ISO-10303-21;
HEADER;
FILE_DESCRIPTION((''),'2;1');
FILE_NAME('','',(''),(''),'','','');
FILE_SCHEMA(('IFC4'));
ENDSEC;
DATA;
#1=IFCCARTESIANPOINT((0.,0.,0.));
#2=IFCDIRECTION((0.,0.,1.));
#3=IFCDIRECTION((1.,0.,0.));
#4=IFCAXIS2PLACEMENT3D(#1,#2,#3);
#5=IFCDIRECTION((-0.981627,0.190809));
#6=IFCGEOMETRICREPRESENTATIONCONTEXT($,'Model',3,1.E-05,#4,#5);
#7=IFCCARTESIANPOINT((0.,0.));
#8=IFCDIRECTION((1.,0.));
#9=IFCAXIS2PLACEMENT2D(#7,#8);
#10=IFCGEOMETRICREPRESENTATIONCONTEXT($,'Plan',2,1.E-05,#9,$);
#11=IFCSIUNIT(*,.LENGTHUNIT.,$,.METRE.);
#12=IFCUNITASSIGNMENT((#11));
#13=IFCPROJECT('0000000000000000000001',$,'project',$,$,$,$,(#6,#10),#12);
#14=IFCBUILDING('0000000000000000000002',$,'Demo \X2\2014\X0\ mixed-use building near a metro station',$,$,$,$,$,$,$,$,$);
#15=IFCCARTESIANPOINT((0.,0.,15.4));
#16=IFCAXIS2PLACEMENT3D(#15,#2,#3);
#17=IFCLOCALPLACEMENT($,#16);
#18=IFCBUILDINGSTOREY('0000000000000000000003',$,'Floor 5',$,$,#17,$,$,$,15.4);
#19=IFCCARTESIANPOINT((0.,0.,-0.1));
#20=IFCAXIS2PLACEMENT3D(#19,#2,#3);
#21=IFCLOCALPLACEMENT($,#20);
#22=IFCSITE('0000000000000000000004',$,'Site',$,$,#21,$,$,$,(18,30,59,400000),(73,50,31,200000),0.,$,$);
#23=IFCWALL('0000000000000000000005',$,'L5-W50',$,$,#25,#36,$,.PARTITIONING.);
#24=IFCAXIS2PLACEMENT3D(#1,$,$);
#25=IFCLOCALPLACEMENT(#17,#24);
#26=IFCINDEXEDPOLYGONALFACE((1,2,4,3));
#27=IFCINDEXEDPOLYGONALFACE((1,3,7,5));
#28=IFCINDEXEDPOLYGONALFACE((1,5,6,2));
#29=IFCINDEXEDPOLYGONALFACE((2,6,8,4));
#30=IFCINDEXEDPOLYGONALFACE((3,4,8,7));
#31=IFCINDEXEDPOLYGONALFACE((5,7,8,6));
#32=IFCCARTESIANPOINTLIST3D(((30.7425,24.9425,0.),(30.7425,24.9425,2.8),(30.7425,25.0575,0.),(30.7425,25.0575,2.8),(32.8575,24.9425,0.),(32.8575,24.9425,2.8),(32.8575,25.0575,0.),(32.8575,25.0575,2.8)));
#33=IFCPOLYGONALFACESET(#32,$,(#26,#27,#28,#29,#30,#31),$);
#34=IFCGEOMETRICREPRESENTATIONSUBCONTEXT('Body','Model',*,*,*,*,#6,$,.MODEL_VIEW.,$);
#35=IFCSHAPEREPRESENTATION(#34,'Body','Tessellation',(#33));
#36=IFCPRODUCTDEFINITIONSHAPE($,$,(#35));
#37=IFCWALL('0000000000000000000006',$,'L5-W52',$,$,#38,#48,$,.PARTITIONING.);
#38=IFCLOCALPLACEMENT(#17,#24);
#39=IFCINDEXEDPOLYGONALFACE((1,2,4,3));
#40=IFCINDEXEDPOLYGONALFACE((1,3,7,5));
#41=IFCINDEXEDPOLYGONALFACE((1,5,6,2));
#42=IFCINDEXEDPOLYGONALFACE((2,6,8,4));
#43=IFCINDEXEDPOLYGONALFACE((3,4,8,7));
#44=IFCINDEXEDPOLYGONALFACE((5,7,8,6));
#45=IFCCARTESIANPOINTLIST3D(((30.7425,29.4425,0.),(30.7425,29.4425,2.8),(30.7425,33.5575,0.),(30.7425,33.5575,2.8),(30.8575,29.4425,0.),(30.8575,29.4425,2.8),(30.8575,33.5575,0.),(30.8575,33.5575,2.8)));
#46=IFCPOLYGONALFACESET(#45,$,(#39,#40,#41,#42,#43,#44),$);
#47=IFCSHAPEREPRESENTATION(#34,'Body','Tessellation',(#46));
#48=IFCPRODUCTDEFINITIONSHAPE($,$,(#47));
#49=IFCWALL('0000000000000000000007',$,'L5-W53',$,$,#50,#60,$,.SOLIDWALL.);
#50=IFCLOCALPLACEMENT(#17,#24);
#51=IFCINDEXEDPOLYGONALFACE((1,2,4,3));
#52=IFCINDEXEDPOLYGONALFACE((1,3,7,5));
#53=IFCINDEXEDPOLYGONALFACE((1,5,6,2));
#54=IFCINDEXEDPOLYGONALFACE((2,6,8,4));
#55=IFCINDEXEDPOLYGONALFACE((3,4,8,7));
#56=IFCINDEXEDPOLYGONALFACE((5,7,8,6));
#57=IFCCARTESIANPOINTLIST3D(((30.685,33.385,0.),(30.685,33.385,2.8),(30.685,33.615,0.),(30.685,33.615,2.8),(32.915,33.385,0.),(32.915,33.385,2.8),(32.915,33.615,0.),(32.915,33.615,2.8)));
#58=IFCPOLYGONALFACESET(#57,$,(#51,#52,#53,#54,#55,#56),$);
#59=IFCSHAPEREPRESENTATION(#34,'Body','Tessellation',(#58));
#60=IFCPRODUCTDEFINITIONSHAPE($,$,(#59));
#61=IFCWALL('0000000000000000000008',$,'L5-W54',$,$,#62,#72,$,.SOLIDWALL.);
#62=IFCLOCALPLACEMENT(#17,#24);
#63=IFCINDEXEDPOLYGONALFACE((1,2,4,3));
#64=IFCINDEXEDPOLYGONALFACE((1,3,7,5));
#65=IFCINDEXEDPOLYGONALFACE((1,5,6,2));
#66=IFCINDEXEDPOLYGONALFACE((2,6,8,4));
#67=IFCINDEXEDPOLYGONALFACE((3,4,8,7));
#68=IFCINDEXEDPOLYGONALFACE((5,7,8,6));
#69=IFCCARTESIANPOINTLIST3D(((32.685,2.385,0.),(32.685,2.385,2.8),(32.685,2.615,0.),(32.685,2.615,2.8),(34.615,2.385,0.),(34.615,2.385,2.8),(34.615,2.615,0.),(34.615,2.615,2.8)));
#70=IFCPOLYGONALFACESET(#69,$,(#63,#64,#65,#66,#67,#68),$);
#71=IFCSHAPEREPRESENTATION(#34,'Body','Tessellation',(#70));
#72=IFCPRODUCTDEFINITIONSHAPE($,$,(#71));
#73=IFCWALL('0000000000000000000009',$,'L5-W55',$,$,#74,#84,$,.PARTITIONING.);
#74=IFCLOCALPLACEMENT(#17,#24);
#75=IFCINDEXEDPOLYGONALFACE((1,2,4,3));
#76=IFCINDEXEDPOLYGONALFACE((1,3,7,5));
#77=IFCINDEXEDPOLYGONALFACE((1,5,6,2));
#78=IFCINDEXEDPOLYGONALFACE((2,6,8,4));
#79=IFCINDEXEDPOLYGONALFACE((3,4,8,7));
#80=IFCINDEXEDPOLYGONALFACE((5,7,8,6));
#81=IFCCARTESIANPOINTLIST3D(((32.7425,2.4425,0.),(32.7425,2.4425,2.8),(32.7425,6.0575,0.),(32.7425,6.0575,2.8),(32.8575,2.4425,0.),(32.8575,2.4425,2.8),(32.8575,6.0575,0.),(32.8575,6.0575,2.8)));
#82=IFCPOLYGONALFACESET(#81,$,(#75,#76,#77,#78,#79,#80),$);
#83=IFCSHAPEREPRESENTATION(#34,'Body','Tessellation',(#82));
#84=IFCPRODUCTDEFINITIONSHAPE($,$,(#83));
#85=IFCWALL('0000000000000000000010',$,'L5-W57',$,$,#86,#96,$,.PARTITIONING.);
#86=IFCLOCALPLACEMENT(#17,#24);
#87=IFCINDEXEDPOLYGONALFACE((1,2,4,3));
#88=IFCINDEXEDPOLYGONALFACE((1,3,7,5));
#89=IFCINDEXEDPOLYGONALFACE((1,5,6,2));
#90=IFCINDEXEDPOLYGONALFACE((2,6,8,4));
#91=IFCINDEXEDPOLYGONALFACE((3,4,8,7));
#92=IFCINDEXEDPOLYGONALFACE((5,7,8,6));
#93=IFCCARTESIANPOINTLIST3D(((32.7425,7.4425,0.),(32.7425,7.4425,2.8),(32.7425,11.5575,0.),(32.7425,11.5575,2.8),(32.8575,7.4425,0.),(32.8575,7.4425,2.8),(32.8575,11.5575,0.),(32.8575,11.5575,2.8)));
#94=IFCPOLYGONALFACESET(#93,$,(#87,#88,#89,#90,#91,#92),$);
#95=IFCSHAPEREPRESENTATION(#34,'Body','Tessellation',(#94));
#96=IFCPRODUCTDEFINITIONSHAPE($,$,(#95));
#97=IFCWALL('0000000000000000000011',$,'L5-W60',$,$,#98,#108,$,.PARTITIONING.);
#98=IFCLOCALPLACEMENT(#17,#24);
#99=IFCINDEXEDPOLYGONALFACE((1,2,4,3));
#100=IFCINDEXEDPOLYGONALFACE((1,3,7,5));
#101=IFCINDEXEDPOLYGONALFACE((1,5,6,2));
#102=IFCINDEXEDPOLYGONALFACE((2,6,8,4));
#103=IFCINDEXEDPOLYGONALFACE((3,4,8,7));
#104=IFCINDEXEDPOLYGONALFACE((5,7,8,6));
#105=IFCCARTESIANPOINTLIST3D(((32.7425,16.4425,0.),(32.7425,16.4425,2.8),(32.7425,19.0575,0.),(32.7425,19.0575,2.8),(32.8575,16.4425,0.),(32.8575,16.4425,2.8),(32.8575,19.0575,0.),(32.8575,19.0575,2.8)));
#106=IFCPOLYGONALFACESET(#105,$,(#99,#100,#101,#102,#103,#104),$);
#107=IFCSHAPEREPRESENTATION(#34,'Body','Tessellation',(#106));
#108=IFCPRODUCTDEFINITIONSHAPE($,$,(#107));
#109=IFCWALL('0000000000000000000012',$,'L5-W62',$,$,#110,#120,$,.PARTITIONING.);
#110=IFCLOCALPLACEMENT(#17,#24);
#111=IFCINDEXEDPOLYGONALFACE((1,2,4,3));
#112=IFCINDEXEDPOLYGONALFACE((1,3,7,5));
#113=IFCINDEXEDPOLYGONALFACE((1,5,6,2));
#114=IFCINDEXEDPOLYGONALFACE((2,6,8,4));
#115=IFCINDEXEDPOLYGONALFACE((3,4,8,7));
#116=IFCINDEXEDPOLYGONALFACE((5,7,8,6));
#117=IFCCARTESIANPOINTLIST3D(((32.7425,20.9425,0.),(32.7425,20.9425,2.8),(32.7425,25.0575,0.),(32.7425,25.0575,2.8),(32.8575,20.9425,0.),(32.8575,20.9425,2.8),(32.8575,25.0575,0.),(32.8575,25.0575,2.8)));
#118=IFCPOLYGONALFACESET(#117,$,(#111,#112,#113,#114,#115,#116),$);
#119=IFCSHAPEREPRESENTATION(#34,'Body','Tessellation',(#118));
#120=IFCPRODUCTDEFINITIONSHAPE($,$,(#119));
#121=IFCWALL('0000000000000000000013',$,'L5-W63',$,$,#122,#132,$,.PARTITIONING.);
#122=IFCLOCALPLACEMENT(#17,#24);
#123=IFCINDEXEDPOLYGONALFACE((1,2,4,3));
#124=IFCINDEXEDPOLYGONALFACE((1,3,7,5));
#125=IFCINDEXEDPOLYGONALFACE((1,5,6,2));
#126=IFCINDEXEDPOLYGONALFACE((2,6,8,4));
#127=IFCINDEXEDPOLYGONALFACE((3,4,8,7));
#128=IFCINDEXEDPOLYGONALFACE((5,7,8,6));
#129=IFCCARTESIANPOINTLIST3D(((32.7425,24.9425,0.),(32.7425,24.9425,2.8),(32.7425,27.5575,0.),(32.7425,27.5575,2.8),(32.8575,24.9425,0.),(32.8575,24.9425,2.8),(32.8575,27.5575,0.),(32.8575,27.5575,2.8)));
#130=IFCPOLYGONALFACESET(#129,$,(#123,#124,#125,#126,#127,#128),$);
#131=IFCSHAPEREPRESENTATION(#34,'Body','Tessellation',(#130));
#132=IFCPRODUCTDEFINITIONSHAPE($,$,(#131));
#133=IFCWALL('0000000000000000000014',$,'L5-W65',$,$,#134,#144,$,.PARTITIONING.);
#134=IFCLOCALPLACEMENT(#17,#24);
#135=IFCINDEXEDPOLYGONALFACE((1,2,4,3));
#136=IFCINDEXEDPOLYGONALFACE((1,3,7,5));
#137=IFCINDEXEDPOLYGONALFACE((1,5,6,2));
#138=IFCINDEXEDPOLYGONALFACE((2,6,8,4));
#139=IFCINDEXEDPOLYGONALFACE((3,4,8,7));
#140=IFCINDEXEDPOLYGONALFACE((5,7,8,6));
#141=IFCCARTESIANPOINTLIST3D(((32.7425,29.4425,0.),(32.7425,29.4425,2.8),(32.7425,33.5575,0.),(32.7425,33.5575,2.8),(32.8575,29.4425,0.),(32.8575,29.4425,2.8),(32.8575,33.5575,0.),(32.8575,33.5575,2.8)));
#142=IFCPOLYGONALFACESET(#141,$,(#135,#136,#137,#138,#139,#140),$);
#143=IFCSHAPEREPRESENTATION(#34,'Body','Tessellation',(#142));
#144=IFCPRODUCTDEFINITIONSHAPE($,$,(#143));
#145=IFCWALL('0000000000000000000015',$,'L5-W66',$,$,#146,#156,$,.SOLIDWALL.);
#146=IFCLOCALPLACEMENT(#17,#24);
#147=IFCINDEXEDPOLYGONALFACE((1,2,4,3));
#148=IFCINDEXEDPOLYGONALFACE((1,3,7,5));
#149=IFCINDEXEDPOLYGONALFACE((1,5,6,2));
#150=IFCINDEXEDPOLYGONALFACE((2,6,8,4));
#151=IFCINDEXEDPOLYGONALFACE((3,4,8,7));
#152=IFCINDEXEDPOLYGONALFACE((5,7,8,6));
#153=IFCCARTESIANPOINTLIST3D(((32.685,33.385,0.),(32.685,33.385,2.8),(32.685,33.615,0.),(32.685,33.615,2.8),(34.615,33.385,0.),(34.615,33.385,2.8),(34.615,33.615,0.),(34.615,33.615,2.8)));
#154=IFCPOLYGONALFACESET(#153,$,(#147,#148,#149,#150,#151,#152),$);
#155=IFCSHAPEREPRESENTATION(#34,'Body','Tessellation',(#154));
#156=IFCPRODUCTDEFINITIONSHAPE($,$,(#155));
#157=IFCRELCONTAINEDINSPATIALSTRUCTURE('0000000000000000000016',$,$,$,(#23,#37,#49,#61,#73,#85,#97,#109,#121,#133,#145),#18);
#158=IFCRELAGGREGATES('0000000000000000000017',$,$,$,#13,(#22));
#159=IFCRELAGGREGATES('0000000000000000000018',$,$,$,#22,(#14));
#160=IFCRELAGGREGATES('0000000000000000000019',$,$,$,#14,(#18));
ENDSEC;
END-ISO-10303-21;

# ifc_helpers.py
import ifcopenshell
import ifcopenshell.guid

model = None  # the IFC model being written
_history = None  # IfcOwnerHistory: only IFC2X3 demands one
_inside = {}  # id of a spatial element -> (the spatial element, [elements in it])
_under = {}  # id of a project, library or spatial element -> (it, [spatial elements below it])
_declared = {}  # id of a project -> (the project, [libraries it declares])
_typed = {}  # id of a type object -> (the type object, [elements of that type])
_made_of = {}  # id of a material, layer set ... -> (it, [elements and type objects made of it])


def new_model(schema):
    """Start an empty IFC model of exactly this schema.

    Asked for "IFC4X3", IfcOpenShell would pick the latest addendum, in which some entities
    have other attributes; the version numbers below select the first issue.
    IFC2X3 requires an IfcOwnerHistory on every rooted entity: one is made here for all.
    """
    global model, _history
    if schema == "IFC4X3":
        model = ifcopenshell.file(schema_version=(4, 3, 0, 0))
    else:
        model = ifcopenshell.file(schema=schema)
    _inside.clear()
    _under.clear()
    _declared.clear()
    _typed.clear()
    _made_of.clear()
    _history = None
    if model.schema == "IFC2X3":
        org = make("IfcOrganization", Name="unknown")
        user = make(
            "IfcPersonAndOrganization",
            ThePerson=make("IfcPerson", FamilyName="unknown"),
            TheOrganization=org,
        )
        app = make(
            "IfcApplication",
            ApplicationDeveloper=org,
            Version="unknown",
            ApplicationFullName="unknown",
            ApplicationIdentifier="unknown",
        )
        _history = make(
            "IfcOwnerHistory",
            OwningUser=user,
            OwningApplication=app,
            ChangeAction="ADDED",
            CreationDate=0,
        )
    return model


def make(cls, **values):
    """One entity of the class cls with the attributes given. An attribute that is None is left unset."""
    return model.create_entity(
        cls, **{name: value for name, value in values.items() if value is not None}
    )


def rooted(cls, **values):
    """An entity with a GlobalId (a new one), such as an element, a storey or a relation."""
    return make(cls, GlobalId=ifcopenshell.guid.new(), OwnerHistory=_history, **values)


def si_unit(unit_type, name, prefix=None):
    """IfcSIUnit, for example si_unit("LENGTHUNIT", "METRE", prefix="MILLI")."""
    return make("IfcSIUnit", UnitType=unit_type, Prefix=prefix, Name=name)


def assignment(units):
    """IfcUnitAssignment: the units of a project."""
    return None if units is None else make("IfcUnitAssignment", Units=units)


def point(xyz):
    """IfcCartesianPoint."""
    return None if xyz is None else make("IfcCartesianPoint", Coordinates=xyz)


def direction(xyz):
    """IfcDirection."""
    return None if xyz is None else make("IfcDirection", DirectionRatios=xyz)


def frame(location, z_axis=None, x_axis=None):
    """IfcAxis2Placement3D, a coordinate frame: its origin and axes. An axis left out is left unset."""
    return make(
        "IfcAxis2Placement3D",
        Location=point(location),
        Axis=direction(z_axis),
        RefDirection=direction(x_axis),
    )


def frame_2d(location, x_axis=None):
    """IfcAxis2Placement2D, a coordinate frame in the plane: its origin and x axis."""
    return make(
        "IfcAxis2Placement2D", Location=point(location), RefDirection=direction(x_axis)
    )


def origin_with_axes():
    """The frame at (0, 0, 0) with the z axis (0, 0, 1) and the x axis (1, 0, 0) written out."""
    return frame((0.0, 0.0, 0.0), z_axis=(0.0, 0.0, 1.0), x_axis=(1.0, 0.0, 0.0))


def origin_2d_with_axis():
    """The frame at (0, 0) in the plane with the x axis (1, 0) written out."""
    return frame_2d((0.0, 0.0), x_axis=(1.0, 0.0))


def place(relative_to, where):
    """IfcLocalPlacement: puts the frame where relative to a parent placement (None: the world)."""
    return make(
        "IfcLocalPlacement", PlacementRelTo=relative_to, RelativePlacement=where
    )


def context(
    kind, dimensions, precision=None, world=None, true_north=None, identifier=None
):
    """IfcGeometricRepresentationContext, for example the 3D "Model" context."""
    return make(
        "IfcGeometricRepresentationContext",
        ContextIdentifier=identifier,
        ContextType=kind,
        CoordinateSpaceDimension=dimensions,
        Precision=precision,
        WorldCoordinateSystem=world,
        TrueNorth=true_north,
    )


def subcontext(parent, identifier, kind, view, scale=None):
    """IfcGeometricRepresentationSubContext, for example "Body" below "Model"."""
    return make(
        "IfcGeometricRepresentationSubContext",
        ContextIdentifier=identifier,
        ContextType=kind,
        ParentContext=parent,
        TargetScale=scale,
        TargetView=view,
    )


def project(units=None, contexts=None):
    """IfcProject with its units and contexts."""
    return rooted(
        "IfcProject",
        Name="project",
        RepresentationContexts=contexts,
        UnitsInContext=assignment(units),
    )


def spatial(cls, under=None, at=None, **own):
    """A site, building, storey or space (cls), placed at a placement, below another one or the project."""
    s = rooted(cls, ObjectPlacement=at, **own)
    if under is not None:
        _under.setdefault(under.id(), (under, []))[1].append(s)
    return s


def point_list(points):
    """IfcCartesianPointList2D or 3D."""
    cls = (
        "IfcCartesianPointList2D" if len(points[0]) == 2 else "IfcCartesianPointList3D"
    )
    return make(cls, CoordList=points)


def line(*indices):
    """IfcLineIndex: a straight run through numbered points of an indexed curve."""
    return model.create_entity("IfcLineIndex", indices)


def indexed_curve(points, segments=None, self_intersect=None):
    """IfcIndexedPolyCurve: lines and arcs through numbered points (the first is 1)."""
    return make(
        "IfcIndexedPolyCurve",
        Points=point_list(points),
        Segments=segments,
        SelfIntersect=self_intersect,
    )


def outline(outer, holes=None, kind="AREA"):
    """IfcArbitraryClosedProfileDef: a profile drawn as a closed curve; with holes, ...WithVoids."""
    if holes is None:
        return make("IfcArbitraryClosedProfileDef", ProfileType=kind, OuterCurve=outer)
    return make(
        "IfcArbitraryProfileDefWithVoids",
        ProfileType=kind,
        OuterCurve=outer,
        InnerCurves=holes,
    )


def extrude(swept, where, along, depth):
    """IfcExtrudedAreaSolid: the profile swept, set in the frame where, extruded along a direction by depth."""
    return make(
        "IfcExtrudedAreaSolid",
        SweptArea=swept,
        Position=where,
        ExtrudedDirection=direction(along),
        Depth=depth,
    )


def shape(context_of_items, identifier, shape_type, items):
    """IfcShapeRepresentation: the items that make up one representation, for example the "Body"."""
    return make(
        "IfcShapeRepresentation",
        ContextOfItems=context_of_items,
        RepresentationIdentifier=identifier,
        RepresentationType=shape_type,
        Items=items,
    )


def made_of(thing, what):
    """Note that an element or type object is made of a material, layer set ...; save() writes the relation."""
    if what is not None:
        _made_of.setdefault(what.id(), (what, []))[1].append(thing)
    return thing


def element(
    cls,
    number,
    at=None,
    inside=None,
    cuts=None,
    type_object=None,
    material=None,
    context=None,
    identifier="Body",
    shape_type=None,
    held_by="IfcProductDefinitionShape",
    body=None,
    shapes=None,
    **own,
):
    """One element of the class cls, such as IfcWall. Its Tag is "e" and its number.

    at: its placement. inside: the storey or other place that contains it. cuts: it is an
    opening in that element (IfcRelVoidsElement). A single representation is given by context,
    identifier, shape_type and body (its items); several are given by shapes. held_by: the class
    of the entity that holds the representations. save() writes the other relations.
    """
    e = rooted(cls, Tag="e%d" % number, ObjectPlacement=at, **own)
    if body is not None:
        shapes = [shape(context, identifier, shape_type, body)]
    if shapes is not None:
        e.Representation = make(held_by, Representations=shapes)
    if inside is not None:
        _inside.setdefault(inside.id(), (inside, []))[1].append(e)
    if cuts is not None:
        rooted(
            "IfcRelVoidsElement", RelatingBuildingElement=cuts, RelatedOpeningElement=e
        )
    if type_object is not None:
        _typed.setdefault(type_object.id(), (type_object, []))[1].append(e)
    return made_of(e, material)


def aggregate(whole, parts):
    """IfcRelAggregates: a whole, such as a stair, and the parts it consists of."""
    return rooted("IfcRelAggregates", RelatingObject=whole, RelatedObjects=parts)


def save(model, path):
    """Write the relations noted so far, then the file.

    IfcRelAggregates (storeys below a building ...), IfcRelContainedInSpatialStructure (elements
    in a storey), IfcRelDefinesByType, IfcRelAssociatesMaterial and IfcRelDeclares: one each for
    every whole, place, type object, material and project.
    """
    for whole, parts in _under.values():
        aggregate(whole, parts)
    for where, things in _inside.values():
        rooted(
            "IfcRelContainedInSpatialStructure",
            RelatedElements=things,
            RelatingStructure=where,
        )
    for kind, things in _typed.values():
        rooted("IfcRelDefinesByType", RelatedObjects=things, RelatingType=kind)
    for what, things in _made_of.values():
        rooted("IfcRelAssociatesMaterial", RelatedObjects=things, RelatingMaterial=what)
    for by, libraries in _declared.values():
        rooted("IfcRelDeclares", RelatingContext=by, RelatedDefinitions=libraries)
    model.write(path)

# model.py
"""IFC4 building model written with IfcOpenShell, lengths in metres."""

from ifc_helpers import new_model, si_unit, direction, frame, origin_with_axes, origin_2d_with_axis, place, context, subcontext, project, spatial, line, indexed_curve, outline, extrude, element, save


model = new_model("IFC4")

# Units and contexts
model_context = context("Model", 3, precision=1e-05, world=origin_with_axes(), true_north=direction((-0.981627, 0.190809)))
plan_context = context("Plan", 2, precision=1e-05, world=origin_2d_with_axis())
body_context = subcontext(model_context, "Body", "Model", "MODEL_VIEW")
ifc_project = project(units=[si_unit("LENGTHUNIT", "METRE")], contexts=[model_context, plan_context])

# Site, building, storey
site_placement = place(None, frame((0.0, 0.0, -0.1), z_axis=(0.0, 0.0, 1.0), x_axis=(1.0, 0.0, 0.0)))
site = spatial("IfcSite", under=ifc_project, at=site_placement, Name="Site", RefLatitude=(18, 30, 59, 400000), RefLongitude=(73, 50, 31, 200000), RefElevation=0.0)
building = spatial("IfcBuilding", under=site, Name="Demo — mixed-use building near a metro station")
storey_placement = place(None, frame((0.0, 0.0, 15.4), z_axis=(0.0, 0.0, 1.0), x_axis=(1.0, 0.0, 0.0)))
storey = spatial("IfcBuildingStorey", under=building, at=storey_placement, Name="Floor 5", Elevation=15.4)

# Wall
wall_1_placement = place(storey_placement, frame((0.0, 0.0, -15.4), z_axis=(0.0, 0.0, 1.0), x_axis=(1.0, 0.0, 0.0)))
element("IfcWall", 1, at=wall_1_placement, inside=storey, Name="L5-W50", PredefinedType="PARTITIONING", context=body_context, shape_type="SweptSolid", body=[
    extrude(outline(indexed_curve([(32.8575, 24.9425), (30.7425, 24.9425), (30.7425, 25.0575), (32.8575, 25.0575)], segments=[line(1, 2, 3, 4, 1)])), frame((0.0, 0.0, 15.4), z_axis=(0.0, 0.0, 1.0), x_axis=(1.0, 0.0, 0.0)), (0.0, 0.0, 1.0), 2.8),
])

# Walls
wall_2_placement = place(storey_placement, frame((0.0, 0.0, -15.4), z_axis=(0.0, 0.0, 1.0), x_axis=(1.0, 0.0, 0.0)))
element("IfcWall", 2, at=wall_2_placement, inside=storey, Name="L5-W52", PredefinedType="PARTITIONING", context=body_context, shape_type="SweptSolid", body=[
    extrude(outline(indexed_curve([(30.7425, 29.4425), (30.7425, 33.5575), (30.8575, 33.5575), (30.8575, 29.4425)], segments=[line(1, 2, 3, 4, 1)])), frame((0.0, 0.0, 15.4), z_axis=(0.0, 0.0, 1.0), x_axis=(1.0, 0.0, 0.0)), (0.0, 0.0, 1.0), 2.8),
])
wall_3_placement = place(storey_placement, frame((0.0, 0.0, -15.4), z_axis=(0.0, 0.0, 1.0), x_axis=(1.0, 0.0, 0.0)))
element("IfcWall", 3, at=wall_3_placement, inside=storey, Name="L5-W53", PredefinedType="SOLIDWALL", context=body_context, shape_type="SweptSolid", body=[
    extrude(outline(indexed_curve([(32.915, 33.385), (30.685, 33.385), (30.685, 33.615), (32.915, 33.615)], segments=[line(1, 2, 3, 4, 1)])), frame((0.0, 0.0, 15.4), z_axis=(0.0, 0.0, 1.0), x_axis=(1.0, 0.0, 0.0)), (0.0, 0.0, 1.0), 2.8),
])
wall_4_placement = place(storey_placement, frame((0.0, 0.0, -15.4), z_axis=(0.0, 0.0, 1.0), x_axis=(1.0, 0.0, 0.0)))
element("IfcWall", 4, at=wall_4_placement, inside=storey, Name="L5-W54", PredefinedType="SOLIDWALL", context=body_context, shape_type="SweptSolid", body=[
    extrude(outline(indexed_curve([(32.685, 2.615), (34.615, 2.615), (34.615, 2.385), (32.685, 2.385)], segments=[line(1, 2, 3, 4, 1)])), frame((0.0, 0.0, 15.4), z_axis=(0.0, 0.0, 1.0), x_axis=(1.0, 0.0, 0.0)), (0.0, 0.0, 1.0), 2.8),
])
wall_5_placement = place(storey_placement, frame((0.0, 0.0, -15.4), z_axis=(0.0, 0.0, 1.0), x_axis=(1.0, 0.0, 0.0)))
element("IfcWall", 5, at=wall_5_placement, inside=storey, Name="L5-W55", PredefinedType="PARTITIONING", context=body_context, shape_type="SweptSolid", body=[
    extrude(outline(indexed_curve([(32.8575, 6.0575), (32.8575, 2.4425), (32.7425, 2.4425), (32.7425, 6.0575)], segments=[line(1, 2, 3, 4, 1)])), frame((0.0, 0.0, 15.4), z_axis=(0.0, 0.0, 1.0), x_axis=(1.0, 0.0, 0.0)), (0.0, 0.0, 1.0), 2.8),
])

# Wall
wall_6_placement = place(storey_placement, frame((0.0, 0.0, -15.4), z_axis=(0.0, 0.0, 1.0), x_axis=(1.0, 0.0, 0.0)))
element("IfcWall", 6, at=wall_6_placement, inside=storey, Name="L5-W57", PredefinedType="PARTITIONING", context=body_context, shape_type="SweptSolid", body=[
    extrude(outline(indexed_curve([(32.8575, 11.5575), (32.8575, 7.4425), (32.7425, 7.4425), (32.7425, 11.5575)], segments=[line(1, 2, 3, 4, 1)])), frame((0.0, 0.0, 15.4), z_axis=(0.0, 0.0, 1.0), x_axis=(1.0, 0.0, 0.0)), (0.0, 0.0, 1.0), 2.8),
])

# Wall
wall_7_placement = place(storey_placement, frame((0.0, 0.0, -15.4), z_axis=(0.0, 0.0, 1.0), x_axis=(1.0, 0.0, 0.0)))
element("IfcWall", 7, at=wall_7_placement, inside=storey, Name="L5-W60", PredefinedType="PARTITIONING", context=body_context, shape_type="SweptSolid", body=[
    extrude(outline(indexed_curve([(32.8575, 19.0575), (32.8575, 16.4425), (32.7425, 16.4425), (32.7425, 19.0575)], segments=[line(1, 2, 3, 4, 1)])), frame((0.0, 0.0, 15.4), z_axis=(0.0, 0.0, 1.0), x_axis=(1.0, 0.0, 0.0)), (0.0, 0.0, 1.0), 2.8),
])

# Walls
wall_8_placement = place(storey_placement, frame((0.0, 0.0, -15.4), z_axis=(0.0, 0.0, 1.0), x_axis=(1.0, 0.0, 0.0)))
element("IfcWall", 8, at=wall_8_placement, inside=storey, Name="L5-W62", PredefinedType="PARTITIONING", context=body_context, shape_type="SweptSolid", body=[
    extrude(outline(indexed_curve([(32.8575, 25.0575), (32.8575, 20.9425), (32.7425, 20.9425), (32.7425, 25.0575)], segments=[line(1, 2, 3, 4, 1)])), frame((0.0, 0.0, 15.4), z_axis=(0.0, 0.0, 1.0), x_axis=(1.0, 0.0, 0.0)), (0.0, 0.0, 1.0), 2.8),
])
wall_9_placement = place(storey_placement, frame((0.0, 0.0, -15.4), z_axis=(0.0, 0.0, 1.0), x_axis=(1.0, 0.0, 0.0)))
element("IfcWall", 9, at=wall_9_placement, inside=storey, Name="L5-W63", PredefinedType="PARTITIONING", context=body_context, shape_type="SweptSolid", body=[
    extrude(outline(indexed_curve([(32.8575, 27.5575), (32.8575, 24.9425), (32.7425, 24.9425), (32.7425, 27.5575)], segments=[line(1, 2, 3, 4, 1)])), frame((0.0, 0.0, 15.4), z_axis=(0.0, 0.0, 1.0), x_axis=(1.0, 0.0, 0.0)), (0.0, 0.0, 1.0), 2.8),
])

# Walls
wall_10_placement = place(storey_placement, frame((0.0, 0.0, -15.4), z_axis=(0.0, 0.0, 1.0), x_axis=(1.0, 0.0, 0.0)))
element("IfcWall", 10, at=wall_10_placement, inside=storey, Name="L5-W65", PredefinedType="PARTITIONING", context=body_context, shape_type="SweptSolid", body=[
    extrude(outline(indexed_curve([(32.8575, 33.5575), (32.8575, 29.4425), (32.7425, 29.4425), (32.7425, 33.5575)], segments=[line(1, 2, 3, 4, 1)])), frame((0.0, 0.0, 15.4), z_axis=(0.0, 0.0, 1.0), x_axis=(1.0, 0.0, 0.0)), (0.0, 0.0, 1.0), 2.8),
])
wall_11_placement = place(storey_placement, frame((0.0, 0.0, -15.4), z_axis=(0.0, 0.0, 1.0), x_axis=(1.0, 0.0, 0.0)))
element("IfcWall", 11, at=wall_11_placement, inside=storey, Name="L5-W66", PredefinedType="SOLIDWALL", context=body_context, shape_type="SweptSolid", body=[
    extrude(outline(indexed_curve([(34.615, 33.385), (32.685, 33.385), (32.685, 33.615), (34.615, 33.615)], segments=[line(1, 2, 3, 4, 1)])), frame((0.0, 0.0, 15.4), z_axis=(0.0, 0.0, 1.0), x_axis=(1.0, 0.0, 0.0)), (0.0, 0.0, 1.0), 2.8),
])

save(model, "model.ifc")
